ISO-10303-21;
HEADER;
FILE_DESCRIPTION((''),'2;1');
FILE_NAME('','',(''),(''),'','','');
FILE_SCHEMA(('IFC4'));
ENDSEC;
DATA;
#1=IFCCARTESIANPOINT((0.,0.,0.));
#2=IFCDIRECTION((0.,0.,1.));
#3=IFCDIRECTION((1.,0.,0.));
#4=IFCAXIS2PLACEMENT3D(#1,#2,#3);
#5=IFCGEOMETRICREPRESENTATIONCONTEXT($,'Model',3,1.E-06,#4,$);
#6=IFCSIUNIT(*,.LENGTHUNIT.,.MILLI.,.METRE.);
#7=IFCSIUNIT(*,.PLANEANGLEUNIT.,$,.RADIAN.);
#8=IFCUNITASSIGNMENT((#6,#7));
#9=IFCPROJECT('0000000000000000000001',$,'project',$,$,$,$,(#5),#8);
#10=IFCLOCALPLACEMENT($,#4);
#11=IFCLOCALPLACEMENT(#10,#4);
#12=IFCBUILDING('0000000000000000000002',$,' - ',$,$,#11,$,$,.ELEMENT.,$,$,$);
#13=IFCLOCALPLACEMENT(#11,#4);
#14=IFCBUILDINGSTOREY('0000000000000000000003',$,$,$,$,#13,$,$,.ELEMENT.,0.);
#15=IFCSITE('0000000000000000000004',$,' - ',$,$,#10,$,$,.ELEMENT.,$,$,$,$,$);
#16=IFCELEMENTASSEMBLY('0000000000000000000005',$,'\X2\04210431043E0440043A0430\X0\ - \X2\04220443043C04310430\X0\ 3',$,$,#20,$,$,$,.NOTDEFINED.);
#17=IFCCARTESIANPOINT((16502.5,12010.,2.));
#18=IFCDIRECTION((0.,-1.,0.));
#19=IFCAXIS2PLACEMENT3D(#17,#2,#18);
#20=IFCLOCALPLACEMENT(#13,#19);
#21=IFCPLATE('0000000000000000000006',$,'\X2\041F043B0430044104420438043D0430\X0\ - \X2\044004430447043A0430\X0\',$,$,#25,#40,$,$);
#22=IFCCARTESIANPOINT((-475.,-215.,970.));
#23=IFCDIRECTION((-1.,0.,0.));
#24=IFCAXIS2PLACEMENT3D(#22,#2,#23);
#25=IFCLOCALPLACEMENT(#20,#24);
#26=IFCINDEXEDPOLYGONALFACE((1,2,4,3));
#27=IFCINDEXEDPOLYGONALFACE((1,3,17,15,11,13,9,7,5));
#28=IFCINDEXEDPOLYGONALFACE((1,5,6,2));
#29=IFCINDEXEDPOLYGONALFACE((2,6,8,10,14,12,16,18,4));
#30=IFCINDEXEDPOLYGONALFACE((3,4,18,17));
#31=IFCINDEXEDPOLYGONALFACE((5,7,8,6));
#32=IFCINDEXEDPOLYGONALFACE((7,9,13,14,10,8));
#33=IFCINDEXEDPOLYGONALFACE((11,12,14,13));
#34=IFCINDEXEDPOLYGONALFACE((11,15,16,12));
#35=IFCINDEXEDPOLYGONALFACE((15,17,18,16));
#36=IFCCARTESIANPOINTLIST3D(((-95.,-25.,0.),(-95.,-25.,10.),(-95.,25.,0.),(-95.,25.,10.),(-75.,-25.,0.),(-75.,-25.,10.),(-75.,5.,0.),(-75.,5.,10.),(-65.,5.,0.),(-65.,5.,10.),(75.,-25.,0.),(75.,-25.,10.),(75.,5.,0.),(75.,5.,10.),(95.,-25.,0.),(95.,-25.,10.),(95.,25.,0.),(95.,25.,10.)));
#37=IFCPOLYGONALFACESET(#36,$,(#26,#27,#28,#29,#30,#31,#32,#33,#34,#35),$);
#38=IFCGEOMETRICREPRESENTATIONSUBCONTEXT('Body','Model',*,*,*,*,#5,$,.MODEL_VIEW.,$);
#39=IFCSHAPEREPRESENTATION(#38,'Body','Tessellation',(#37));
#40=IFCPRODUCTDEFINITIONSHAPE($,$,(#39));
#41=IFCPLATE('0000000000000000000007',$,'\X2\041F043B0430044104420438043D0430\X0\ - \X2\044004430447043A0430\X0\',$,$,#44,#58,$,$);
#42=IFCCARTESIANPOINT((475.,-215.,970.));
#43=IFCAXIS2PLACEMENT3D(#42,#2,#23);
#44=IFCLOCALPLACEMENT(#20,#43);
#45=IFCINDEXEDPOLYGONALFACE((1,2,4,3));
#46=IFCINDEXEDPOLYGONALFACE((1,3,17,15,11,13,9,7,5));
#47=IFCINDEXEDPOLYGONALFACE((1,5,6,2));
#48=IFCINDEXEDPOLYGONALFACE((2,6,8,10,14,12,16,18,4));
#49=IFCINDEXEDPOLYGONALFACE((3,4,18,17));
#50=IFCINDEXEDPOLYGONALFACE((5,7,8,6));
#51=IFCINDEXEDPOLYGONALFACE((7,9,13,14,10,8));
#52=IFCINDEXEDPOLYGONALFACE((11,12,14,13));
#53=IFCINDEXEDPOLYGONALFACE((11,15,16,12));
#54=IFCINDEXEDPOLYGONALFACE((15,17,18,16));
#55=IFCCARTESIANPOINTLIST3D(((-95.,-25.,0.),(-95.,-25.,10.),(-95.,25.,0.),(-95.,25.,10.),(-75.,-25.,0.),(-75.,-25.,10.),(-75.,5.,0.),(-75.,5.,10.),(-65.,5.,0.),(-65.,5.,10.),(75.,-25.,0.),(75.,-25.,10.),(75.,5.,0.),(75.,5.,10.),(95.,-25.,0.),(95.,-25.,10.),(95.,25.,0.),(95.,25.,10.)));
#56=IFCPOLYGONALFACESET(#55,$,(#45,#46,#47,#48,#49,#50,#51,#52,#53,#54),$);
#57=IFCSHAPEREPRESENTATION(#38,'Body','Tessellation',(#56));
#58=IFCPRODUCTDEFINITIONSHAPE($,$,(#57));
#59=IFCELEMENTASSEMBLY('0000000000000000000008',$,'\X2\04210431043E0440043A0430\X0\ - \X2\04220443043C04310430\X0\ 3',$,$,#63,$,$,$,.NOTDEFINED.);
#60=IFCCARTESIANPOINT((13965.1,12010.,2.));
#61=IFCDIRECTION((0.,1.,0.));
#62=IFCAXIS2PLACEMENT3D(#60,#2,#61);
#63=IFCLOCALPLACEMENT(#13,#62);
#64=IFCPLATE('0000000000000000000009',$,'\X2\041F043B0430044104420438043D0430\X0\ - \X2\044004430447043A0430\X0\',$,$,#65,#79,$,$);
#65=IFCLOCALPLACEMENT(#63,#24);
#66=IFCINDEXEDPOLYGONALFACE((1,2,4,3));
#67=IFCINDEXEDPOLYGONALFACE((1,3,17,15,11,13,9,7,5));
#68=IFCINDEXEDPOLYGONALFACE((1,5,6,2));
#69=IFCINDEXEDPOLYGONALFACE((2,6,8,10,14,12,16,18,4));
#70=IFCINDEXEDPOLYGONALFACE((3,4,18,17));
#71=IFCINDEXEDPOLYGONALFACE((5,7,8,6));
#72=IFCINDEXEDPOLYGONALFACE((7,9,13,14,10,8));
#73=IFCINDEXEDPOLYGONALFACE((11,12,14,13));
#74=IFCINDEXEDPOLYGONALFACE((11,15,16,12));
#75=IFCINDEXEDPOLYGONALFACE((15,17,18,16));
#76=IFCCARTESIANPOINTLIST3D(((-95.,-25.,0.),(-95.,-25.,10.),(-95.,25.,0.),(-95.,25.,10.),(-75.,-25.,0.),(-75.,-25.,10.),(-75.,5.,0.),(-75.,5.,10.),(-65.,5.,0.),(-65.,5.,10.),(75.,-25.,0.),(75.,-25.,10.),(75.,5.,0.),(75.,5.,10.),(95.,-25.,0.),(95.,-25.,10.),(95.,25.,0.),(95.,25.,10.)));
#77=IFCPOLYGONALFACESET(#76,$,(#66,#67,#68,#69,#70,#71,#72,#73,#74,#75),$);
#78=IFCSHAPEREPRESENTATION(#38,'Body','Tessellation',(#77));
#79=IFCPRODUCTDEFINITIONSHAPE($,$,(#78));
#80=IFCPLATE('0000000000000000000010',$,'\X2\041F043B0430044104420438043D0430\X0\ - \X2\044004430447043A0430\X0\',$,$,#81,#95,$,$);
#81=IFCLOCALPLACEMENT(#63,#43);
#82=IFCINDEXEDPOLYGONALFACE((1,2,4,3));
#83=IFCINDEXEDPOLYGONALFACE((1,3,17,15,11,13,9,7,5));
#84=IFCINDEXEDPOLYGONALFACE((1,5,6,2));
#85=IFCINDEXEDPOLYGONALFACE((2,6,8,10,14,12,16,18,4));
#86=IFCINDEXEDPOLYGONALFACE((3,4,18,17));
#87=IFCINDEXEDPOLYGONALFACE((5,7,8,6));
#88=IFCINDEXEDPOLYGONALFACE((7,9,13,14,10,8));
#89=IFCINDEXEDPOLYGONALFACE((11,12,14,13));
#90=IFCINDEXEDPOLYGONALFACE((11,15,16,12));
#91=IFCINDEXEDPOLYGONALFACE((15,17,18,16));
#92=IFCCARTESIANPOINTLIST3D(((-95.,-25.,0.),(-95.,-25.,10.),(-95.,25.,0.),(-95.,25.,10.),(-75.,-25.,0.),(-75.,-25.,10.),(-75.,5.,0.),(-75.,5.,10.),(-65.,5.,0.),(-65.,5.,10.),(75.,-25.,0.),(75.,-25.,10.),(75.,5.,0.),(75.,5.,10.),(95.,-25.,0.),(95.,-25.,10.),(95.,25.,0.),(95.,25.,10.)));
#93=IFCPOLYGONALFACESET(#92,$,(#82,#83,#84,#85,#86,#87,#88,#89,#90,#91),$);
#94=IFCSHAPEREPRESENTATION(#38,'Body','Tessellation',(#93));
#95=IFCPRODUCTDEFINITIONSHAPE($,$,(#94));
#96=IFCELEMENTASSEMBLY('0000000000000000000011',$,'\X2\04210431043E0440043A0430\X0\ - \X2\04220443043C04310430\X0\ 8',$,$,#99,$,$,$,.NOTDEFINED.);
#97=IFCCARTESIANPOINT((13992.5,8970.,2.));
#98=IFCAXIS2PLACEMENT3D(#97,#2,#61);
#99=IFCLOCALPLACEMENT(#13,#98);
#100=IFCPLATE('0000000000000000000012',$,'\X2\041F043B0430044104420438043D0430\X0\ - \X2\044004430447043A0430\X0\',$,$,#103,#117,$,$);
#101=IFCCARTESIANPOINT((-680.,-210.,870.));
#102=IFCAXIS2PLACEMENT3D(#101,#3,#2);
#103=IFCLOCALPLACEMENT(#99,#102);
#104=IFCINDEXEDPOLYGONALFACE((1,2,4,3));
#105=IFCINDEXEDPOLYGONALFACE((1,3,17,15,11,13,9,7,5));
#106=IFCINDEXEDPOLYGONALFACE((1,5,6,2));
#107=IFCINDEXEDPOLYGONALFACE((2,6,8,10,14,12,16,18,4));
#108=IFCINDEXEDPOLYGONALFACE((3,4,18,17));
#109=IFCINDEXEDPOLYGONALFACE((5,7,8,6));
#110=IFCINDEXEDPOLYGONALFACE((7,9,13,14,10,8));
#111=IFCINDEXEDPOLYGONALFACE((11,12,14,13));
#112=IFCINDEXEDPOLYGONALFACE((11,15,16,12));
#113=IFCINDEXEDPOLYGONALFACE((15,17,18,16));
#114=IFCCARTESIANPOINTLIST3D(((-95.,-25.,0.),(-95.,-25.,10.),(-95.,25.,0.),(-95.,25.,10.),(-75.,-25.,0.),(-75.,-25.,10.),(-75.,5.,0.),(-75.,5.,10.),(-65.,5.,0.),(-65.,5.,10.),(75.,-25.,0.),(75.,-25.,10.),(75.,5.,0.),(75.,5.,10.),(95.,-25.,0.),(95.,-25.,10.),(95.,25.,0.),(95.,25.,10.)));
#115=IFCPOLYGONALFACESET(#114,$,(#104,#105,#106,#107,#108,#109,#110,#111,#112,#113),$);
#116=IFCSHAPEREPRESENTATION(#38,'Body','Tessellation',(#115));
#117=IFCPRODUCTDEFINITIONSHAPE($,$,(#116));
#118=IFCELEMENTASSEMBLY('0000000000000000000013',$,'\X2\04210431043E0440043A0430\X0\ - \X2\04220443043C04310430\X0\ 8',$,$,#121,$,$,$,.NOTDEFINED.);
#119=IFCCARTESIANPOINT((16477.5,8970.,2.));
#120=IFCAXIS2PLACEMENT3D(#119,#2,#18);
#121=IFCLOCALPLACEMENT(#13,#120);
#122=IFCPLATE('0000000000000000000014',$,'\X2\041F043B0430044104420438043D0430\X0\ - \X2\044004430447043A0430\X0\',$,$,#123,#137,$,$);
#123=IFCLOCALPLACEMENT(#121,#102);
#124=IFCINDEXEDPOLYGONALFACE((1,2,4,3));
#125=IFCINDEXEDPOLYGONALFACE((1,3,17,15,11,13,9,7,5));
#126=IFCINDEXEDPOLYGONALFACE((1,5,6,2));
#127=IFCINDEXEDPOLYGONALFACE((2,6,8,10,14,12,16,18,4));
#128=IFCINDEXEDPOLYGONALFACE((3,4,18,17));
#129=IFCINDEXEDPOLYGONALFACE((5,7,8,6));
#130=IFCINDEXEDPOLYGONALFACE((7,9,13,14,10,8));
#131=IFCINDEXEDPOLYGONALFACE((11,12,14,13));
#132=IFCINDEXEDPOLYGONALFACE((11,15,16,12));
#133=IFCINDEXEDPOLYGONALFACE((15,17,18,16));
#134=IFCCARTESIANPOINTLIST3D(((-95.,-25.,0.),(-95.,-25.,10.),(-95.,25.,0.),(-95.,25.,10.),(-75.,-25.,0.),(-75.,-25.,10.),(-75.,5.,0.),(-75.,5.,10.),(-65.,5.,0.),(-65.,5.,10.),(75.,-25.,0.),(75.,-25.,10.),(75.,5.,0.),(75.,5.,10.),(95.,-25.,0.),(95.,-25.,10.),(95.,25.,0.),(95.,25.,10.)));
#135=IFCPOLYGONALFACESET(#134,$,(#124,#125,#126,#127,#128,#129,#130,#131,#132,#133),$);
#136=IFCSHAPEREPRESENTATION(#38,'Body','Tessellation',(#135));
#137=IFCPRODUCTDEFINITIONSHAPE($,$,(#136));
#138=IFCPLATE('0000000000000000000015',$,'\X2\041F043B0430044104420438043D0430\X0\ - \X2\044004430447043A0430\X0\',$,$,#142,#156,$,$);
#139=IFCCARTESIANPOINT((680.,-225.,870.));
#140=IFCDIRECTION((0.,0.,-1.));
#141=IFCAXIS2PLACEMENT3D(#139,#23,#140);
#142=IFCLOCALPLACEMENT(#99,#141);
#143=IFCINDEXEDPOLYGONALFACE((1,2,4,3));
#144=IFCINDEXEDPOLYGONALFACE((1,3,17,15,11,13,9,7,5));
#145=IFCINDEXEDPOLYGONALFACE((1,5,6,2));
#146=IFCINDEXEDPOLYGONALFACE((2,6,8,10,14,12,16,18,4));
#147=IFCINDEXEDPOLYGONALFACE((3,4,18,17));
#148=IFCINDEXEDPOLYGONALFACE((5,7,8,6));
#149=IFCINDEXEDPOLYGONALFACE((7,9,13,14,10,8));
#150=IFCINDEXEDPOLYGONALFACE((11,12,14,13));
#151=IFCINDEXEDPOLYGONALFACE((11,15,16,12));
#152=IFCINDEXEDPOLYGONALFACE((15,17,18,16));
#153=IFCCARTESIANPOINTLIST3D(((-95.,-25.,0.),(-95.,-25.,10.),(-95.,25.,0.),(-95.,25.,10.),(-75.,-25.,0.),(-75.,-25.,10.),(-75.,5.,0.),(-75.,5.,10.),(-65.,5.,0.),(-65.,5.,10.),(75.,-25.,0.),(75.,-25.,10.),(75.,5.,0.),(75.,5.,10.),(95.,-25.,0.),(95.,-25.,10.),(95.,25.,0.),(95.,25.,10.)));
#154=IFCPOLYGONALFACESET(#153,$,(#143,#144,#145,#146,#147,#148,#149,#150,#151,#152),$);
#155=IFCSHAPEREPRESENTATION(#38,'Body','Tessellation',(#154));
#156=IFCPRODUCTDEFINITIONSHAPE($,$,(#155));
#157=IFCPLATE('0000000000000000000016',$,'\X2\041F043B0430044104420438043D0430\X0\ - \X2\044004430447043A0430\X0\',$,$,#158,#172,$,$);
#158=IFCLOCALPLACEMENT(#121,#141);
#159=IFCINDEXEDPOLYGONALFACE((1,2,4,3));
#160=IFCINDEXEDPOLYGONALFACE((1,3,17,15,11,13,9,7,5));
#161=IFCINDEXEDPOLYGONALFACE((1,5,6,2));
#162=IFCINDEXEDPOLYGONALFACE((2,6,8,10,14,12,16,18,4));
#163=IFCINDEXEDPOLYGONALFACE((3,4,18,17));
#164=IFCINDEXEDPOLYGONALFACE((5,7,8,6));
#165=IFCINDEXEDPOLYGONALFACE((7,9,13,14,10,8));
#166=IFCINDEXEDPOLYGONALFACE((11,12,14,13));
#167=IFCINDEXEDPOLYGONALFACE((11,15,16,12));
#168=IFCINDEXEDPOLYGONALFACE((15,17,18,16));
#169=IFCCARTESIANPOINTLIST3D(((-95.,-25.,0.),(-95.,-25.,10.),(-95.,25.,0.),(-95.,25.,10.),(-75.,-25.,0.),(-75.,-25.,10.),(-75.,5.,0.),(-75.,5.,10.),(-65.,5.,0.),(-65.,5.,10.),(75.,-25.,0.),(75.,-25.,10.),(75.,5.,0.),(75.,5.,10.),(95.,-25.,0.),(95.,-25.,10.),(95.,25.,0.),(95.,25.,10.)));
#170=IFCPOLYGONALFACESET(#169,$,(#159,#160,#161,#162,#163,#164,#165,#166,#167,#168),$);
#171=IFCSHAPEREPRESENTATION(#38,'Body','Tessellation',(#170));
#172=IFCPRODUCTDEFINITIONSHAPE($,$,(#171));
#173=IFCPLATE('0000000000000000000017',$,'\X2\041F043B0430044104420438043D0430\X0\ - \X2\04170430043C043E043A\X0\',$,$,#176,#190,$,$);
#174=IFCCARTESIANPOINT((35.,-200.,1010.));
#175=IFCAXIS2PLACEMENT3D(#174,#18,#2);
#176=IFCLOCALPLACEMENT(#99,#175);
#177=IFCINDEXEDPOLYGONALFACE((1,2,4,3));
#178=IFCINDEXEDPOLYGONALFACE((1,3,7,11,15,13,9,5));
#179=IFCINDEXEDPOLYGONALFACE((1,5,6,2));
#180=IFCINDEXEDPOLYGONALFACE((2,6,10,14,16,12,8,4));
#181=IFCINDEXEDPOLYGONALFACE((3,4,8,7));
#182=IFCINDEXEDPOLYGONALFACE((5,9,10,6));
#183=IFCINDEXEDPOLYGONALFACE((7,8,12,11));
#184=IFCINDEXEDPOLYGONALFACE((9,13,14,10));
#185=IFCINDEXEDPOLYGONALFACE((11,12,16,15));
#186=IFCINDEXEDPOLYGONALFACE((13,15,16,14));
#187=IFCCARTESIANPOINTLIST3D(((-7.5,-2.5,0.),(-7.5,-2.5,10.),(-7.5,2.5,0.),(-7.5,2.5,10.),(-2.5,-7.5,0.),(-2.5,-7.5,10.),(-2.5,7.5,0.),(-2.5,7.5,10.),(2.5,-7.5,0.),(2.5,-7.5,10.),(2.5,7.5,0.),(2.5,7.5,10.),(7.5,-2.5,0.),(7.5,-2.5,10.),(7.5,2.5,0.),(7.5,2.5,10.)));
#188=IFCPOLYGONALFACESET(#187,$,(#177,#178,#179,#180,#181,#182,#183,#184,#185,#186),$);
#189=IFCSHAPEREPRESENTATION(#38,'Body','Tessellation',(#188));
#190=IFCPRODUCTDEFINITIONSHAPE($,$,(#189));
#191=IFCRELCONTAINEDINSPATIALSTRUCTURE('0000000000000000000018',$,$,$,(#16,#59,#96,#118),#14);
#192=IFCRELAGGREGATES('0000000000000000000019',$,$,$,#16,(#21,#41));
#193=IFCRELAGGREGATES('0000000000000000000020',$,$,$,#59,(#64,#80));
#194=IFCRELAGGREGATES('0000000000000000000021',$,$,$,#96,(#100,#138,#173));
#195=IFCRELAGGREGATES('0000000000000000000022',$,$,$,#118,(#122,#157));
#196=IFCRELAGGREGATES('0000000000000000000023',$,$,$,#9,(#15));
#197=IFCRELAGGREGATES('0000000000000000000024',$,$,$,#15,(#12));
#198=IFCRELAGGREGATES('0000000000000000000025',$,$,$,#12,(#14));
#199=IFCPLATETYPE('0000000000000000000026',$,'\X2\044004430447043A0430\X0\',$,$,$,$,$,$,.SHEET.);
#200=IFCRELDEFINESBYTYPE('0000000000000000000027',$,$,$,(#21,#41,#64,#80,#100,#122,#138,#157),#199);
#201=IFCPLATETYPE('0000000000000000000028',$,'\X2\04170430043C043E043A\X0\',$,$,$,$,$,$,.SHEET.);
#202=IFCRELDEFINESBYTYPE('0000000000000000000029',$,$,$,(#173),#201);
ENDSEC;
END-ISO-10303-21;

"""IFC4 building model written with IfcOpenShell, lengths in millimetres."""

from ifc_helpers import new_model, si_unit, frame, origin_with_axes, place, context, subcontext, project, spatial, line, indexed_curve, outline, extrude, source, transform, mapped, type_object, element, aggregate, save


model = new_model("IFC4")

# Units and contexts
model_context = context("Model", 3, precision=1e-06, world=origin_with_axes())
body_context = subcontext(model_context, "Body", "Model", "MODEL_VIEW")
ifc_project = project(units=[si_unit("LENGTHUNIT", "METRE", prefix="MILLI"), si_unit("PLANEANGLEUNIT", "RADIAN")], contexts=[model_context])

# Site, building, storey
site_placement = place(None, origin_with_axes())
site = spatial("IfcSite", under=ifc_project, at=site_placement, Name=" - ", CompositionType="ELEMENT")
building_placement = place(site_placement, origin_with_axes())
building = spatial("IfcBuilding", under=site, at=building_placement, Name=" - ", CompositionType="ELEMENT")
storey_placement = place(building_placement, origin_with_axes())
storey = spatial("IfcBuildingStorey", under=building, at=storey_placement, CompositionType="ELEMENT", Elevation=0.0)

# Element assemblies, plates
assembly_1_placement = place(storey_placement, frame((16502.5, 12010.0, 2.0), z_axis=(0.0, 0.0, 1.0), x_axis=(0.0, -1.0, 0.0)))
assembly_1 = element("IfcElementAssembly", 1, at=assembly_1_placement, inside=storey, Name="Сборка - Тумба 3", PredefinedType="NOTDEFINED")
plate_type_1 = type_object("IfcPlateType", Name="ручка", PredefinedType="SHEET")
shared_shape_1 = source(origin_with_axes(), body_context, "Body", "SweptSolid", [
    extrude(outline(indexed_curve([(-95.0, -25.0), (-75.0, -25.0), (-75.0, 5.0), (-65.0, 5.0), (75.0, 5.0), (75.0, -25.0), (95.0, -25.0), (95.0, 25.0), (-95.0, 25.0)], segments=[line(1, 2), line(2, 3), line(3, 4), line(4, 5), line(5, 6), line(6, 7), line(7, 8), line(8, 9), line(9, 1)])), origin_with_axes(), (0.0, 0.0, 1.0), 10.0),
])
plate_1_placement = place(assembly_1_placement, frame((-475.0, -215.0, 970.0), z_axis=(0.0, 0.0, 1.0), x_axis=(-1.0, 0.0, 0.0)))
plate_1 = element("IfcPlate", 2, at=plate_1_placement, type_object=plate_type_1, Name="Пластина - ручка", context=body_context, shape_type="MappedRepresentation", body=[
    mapped(shared_shape_1, transform((0.0, 0.0, 0.0), x_axis=(1.0, 0.0, 0.0), y_axis=(0.0, 1.0, 0.0), z_axis=(0.0, 0.0, 1.0), scale=1.0)),
])
plate_2_placement = place(assembly_1_placement, frame((475.0, -215.0, 970.0), z_axis=(0.0, 0.0, 1.0), x_axis=(-1.0, 0.0, 0.0)))
plate_2 = element("IfcPlate", 3, at=plate_2_placement, type_object=plate_type_1, Name="Пластина - ручка", context=body_context, shape_type="MappedRepresentation", body=[
    mapped(shared_shape_1, transform((0.0, 0.0, 0.0), x_axis=(1.0, 0.0, 0.0), y_axis=(0.0, 1.0, 0.0), z_axis=(0.0, 0.0, 1.0), scale=1.0)),
])
aggregate(assembly_1, [plate_1, plate_2])
assembly_2_placement = place(storey_placement, frame((13965.1, 12010.0, 2.0), z_axis=(0.0, 0.0, 1.0), x_axis=(0.0, 1.0, 0.0)))
assembly_2 = element("IfcElementAssembly", 4, at=assembly_2_placement, inside=storey, Name="Сборка - Тумба 3", PredefinedType="NOTDEFINED")
plate_3_placement = place(assembly_2_placement, frame((-475.0, -215.0, 970.0), z_axis=(0.0, 0.0, 1.0), x_axis=(-1.0, 0.0, 0.0)))
plate_3 = element("IfcPlate", 5, at=plate_3_placement, type_object=plate_type_1, Name="Пластина - ручка", context=body_context, shape_type="MappedRepresentation", body=[
    mapped(shared_shape_1, transform((0.0, 0.0, 0.0), x_axis=(1.0, 0.0, 0.0), y_axis=(0.0, 1.0, 0.0), z_axis=(0.0, 0.0, 1.0), scale=1.0)),
])
plate_4_placement = place(assembly_2_placement, frame((475.0, -215.0, 970.0), z_axis=(0.0, 0.0, 1.0), x_axis=(-1.0, 0.0, 0.0)))
plate_4 = element("IfcPlate", 6, at=plate_4_placement, type_object=plate_type_1, Name="Пластина - ручка", context=body_context, shape_type="MappedRepresentation", body=[
    mapped(shared_shape_1, transform((0.0, 0.0, 0.0), x_axis=(1.0, 0.0, 0.0), y_axis=(0.0, 1.0, 0.0), z_axis=(0.0, 0.0, 1.0), scale=1.0)),
])
aggregate(assembly_2, [plate_3, plate_4])

# Element assemblies, plates
assembly_3_placement = place(storey_placement, frame((13992.5, 8970.0, 2.0), z_axis=(0.0, 0.0, 1.0), x_axis=(0.0, 1.0, 0.0)))
assembly_3 = element("IfcElementAssembly", 7, at=assembly_3_placement, inside=storey, Name="Сборка - Тумба 8", PredefinedType="NOTDEFINED")
shared_shape_2 = source(origin_with_axes(), body_context, "Body", "SweptSolid", [
    extrude(outline(indexed_curve([(-95.0, -25.0), (-75.0, -25.0), (-75.0, 5.0), (-65.0, 5.0), (75.0, 5.0), (75.0, -25.0), (95.0, -25.0), (95.0, 25.0), (-95.0, 25.0)], segments=[line(1, 2), line(2, 3), line(3, 4), line(4, 5), line(5, 6), line(6, 7), line(7, 8), line(8, 9), line(9, 1)])), origin_with_axes(), (0.0, 0.0, 1.0), 10.0),
])
plate_5_placement = place(assembly_3_placement, frame((-680.0, -210.0, 870.0), z_axis=(1.0, 0.0, 0.0), x_axis=(0.0, 0.0, 1.0)))
plate_5 = element("IfcPlate", 8, at=plate_5_placement, type_object=plate_type_1, Name="Пластина - ручка", context=body_context, shape_type="MappedRepresentation", body=[
    mapped(shared_shape_2, transform((0.0, 0.0, 0.0), x_axis=(1.0, 0.0, 0.0), y_axis=(0.0, 1.0, 0.0), z_axis=(0.0, 0.0, 1.0), scale=1.0)),
])
assembly_4_placement = place(storey_placement, frame((16477.5, 8970.0, 2.0), z_axis=(0.0, 0.0, 1.0), x_axis=(0.0, -1.0, 0.0)))
assembly_4 = element("IfcElementAssembly", 9, at=assembly_4_placement, inside=storey, Name="Сборка - Тумба 8", PredefinedType="NOTDEFINED")
plate_6_placement = place(assembly_4_placement, frame((-680.0, -210.0, 870.0), z_axis=(1.0, 0.0, 0.0), x_axis=(0.0, 0.0, 1.0)))
plate_6 = element("IfcPlate", 10, at=plate_6_placement, type_object=plate_type_1, Name="Пластина - ручка", context=body_context, shape_type="MappedRepresentation", body=[
    mapped(shared_shape_2, transform((0.0, 0.0, 0.0), x_axis=(1.0, 0.0, 0.0), y_axis=(0.0, 1.0, 0.0), z_axis=(0.0, 0.0, 1.0), scale=1.0)),
])

# Plates
shared_shape_3 = source(origin_with_axes(), body_context, "Body", "SweptSolid", [
    extrude(outline(indexed_curve([(-95.0, -25.0), (-75.0, -25.0), (-75.0, 5.0), (-65.0, 5.0), (75.0, 5.0), (75.0, -25.0), (95.0, -25.0), (95.0, 25.0), (-95.0, 25.0)], segments=[line(1, 2), line(2, 3), line(3, 4), line(4, 5), line(5, 6), line(6, 7), line(7, 8), line(8, 9), line(9, 1)])), origin_with_axes(), (0.0, 0.0, 1.0), 10.0),
])
plate_7_placement = place(assembly_3_placement, frame((680.0, -225.0, 870.0), z_axis=(-1.0, 0.0, 0.0), x_axis=(0.0, 0.0, -1.0)))
plate_7 = element("IfcPlate", 11, at=plate_7_placement, type_object=plate_type_1, Name="Пластина - ручка", context=body_context, shape_type="MappedRepresentation", body=[
    mapped(shared_shape_3, transform((0.0, 0.0, 0.0), x_axis=(1.0, 0.0, 0.0), y_axis=(0.0, 1.0, 0.0), z_axis=(0.0, 0.0, 1.0), scale=1.0)),
])
plate_8_placement = place(assembly_4_placement, frame((680.0, -225.0, 870.0), z_axis=(-1.0, 0.0, 0.0), x_axis=(0.0, 0.0, -1.0)))
plate_8 = element("IfcPlate", 12, at=plate_8_placement, type_object=plate_type_1, Name="Пластина - ручка", context=body_context, shape_type="MappedRepresentation", body=[
    mapped(shared_shape_3, transform((0.0, 0.0, 0.0), x_axis=(1.0, 0.0, 0.0), y_axis=(0.0, 1.0, 0.0), z_axis=(0.0, 0.0, 1.0), scale=1.0)),
])
plate_type_2 = type_object("IfcPlateType", Name="Замок", PredefinedType="SHEET")
shared_shape_4 = source(origin_with_axes(), body_context, "Body", "SweptSolid", [
    extrude(outline(indexed_curve([(-2.5, 7.5), (-7.5, 2.5), (-7.5, -2.5), (-2.5, -7.5), (2.5, -7.5), (7.5, -2.5), (7.5, 2.5), (2.5, 7.5)], segments=[line(1, 2), line(2, 3), line(3, 4), line(4, 5), line(5, 6), line(6, 7), line(7, 8), line(8, 1)])), origin_with_axes(), (0.0, 0.0, 1.0), 10.0),
])
plate_9_placement = place(assembly_3_placement, frame((35.0, -200.0, 1010.0), z_axis=(0.0, -1.0, 0.0), x_axis=(0.0, 0.0, 1.0)))
plate_9 = element("IfcPlate", 13, at=plate_9_placement, type_object=plate_type_2, Name="Пластина - Замок", context=body_context, shape_type="MappedRepresentation", body=[
    mapped(shared_shape_4, transform((0.0, 0.0, 0.0), x_axis=(1.0, 0.0, 0.0), y_axis=(0.0, 1.0, 0.0), z_axis=(0.0, 0.0, 1.0), scale=1.0)),
])
aggregate(assembly_3, [plate_5, plate_7, plate_9])
aggregate(assembly_4, [plate_6, plate_8])

save(model, "model.ifc")
